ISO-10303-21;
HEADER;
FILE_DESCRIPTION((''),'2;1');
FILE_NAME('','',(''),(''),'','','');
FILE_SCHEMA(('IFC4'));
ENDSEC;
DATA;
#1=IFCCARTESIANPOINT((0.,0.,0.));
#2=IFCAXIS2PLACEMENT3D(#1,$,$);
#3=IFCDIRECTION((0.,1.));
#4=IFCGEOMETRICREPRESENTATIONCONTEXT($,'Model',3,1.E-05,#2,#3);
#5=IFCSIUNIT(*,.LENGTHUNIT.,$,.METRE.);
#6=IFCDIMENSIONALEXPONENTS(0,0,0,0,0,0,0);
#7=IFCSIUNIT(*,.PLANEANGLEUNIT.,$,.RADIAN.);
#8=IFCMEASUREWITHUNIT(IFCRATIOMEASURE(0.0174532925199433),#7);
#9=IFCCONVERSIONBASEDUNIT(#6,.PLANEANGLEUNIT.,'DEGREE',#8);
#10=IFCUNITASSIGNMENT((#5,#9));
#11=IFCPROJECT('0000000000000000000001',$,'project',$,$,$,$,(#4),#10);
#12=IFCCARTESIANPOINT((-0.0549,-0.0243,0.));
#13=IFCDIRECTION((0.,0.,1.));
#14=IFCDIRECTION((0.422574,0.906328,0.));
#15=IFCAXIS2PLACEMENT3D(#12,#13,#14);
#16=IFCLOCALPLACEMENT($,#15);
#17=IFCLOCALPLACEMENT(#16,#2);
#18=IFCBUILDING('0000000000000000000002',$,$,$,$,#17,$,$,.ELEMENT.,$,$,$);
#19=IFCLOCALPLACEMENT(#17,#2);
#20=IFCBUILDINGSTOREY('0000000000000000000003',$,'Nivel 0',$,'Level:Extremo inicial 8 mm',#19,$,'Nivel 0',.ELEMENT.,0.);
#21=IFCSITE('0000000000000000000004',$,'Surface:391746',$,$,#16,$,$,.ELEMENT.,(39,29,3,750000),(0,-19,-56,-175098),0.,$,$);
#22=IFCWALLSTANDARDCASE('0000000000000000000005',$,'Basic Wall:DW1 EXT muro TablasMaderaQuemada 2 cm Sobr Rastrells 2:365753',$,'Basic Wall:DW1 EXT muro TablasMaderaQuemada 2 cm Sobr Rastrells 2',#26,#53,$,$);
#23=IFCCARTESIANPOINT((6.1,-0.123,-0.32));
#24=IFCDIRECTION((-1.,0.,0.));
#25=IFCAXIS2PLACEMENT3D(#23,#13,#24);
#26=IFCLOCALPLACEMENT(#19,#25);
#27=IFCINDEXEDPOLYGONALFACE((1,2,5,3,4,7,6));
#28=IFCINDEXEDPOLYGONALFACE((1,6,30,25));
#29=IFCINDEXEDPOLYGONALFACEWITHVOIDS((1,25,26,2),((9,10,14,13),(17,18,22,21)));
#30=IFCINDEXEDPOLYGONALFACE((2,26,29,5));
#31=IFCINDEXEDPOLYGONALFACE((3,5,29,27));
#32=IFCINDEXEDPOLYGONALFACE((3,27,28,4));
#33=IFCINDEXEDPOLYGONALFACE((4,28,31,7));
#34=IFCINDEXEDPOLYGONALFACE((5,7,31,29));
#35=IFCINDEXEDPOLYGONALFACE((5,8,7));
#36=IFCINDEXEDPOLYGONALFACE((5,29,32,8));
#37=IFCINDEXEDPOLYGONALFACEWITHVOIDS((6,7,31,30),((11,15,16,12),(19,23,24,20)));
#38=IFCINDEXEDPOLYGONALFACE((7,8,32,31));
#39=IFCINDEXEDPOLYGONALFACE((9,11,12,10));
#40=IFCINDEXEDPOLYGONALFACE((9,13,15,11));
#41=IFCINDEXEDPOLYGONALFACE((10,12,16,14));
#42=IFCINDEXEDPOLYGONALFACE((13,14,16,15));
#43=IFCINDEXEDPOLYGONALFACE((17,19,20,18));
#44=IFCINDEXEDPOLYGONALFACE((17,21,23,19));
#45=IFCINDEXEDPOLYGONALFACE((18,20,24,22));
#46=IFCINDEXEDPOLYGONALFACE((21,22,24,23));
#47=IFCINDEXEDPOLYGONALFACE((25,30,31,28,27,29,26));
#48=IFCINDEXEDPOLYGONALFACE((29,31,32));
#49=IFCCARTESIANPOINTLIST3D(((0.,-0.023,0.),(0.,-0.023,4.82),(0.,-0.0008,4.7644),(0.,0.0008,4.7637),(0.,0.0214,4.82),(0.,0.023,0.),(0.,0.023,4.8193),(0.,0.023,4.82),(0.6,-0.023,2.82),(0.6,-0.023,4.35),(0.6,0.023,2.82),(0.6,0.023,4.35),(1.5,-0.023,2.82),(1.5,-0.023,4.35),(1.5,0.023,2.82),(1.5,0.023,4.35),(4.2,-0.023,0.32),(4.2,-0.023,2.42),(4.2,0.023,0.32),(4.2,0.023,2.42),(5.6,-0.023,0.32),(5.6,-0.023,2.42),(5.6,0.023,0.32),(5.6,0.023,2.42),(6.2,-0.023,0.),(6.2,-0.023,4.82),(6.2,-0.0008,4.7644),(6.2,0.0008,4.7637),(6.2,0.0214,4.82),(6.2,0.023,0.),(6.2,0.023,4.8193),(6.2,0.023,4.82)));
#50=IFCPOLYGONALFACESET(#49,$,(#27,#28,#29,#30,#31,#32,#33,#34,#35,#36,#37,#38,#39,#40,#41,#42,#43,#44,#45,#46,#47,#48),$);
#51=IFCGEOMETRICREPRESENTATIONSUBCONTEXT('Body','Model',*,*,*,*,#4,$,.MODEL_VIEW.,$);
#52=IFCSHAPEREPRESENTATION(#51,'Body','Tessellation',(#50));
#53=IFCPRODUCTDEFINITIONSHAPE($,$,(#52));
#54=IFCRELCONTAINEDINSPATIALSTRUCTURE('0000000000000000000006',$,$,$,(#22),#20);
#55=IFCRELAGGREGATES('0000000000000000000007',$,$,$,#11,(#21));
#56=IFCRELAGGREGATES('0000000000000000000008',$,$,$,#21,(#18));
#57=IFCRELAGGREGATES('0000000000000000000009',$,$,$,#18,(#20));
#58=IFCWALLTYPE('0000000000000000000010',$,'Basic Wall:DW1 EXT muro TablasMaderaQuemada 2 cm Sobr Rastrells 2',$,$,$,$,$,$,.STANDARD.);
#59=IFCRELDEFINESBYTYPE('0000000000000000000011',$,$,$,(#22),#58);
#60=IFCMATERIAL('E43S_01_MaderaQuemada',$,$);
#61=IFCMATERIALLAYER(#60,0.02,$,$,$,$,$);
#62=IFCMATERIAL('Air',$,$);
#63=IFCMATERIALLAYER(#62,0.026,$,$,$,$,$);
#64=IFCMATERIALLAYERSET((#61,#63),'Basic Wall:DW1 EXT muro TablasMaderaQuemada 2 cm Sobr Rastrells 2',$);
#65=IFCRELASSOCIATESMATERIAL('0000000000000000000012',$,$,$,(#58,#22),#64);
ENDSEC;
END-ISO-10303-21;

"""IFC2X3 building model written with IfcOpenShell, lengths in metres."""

from ifc_helpers import new_model, entity, si_unit, converted_unit, direction, frame, frame_2d, origin, origin_2d_with_axis, place, context, subcontext, project, spatial, rectangle, extrude, material, layer, layer_set, layer_usage, type_object, element, save


model = new_model("IFC2X3")

# Units and contexts
model_context = context("Model", 3, precision=1e-05, world=origin(), true_north=direction((0.0, 1.0)))
body_context = subcontext(model_context, "Body", "Model", "MODEL_VIEW")
ifc_project = project(units=[si_unit("LENGTHUNIT", "METRE"), converted_unit("PLANEANGLEUNIT", "DEGREE", entity("IfcRatioMeasure", 0.0174532925199433), si_unit("PLANEANGLEUNIT", "RADIAN"), dimensions=[0, 0, 0, 0, 0, 0, 0])], contexts=[model_context])

# Site, building, storey
site_placement = place(None, frame((-0.0549, -0.0243, 0.0), z_axis=(0.0, 0.0, 1.0), x_axis=(0.422574, 0.906328, 0.0)))
site = spatial("IfcSite", under=ifc_project, at=site_placement, Name="Surface:391746", CompositionType="ELEMENT", RefLatitude=(39, 29, 3, 750000), RefLongitude=(0, -19, -56, -175098), RefElevation=0.0)
building_placement = place(site_placement, origin())
building = spatial("IfcBuilding", under=site, at=building_placement, CompositionType="ELEMENT")
storey_placement = place(building_placement, origin())
storey = spatial("IfcBuildingStorey", under=building, at=storey_placement, Name="Nivel 0", ObjectType="Level:Extremo inicial 8 mm", LongName="Nivel 0", CompositionType="ELEMENT", Elevation=0.0)

# Shared definitions
ifc_material_1 = material(Name="E43S_01_MaderaQuemada")
ifc_layer_1 = layer(ifc_material_1, 0.02)
ifc_material_2 = material(Name="Air")
ifc_layer_2 = layer(ifc_material_2, 0.026)
ifc_layer_set_1 = layer_set([ifc_layer_1, ifc_layer_2], Name="Basic Wall:DW1 EXT muro TablasMaderaQuemada 2 cm Sobr Rastrells 2")
wall_type_1 = type_object("IfcWallType", Name="Basic Wall:DW1 EXT muro TablasMaderaQuemada 2 cm Sobr Rastrells 2", PredefinedType="STANDARD", material=ifc_layer_set_1)

# Wall, openings
ifc_layer_usage_1 = layer_usage(ifc_layer_set_1, "AXIS2", "NEGATIVE", 0.023)
wall_1_placement = place(storey_placement, frame((6.1, -0.123, -0.32), z_axis=(0.0, 0.0, 1.0), x_axis=(-1.0, 0.0, 0.0)))
wall_1 = element("IfcWallStandardCase", 1, at=wall_1_placement, inside=storey, type_object=wall_type_1, material=ifc_layer_usage_1, Name="Basic Wall:DW1 EXT muro TablasMaderaQuemada 2 cm Sobr Rastrells 2:365753", ObjectType="Basic Wall:DW1 EXT muro TablasMaderaQuemada 2 cm Sobr Rastrells 2", context=body_context, shape_type="SweptSolid", body=[
    extrude(rectangle(XDim=6.2, YDim=0.046, at=frame_2d((3.1, 0.0), x_axis=(-1.0, 0.0))), origin(), (0.0, 0.0, 1.0), 4.82),
])
opening_1_placement = place(storey_placement, frame((6.1, -0.123, -0.32), z_axis=(0.0, 0.0, 1.0), x_axis=(-1.0, 0.0, 0.0)))
element("IfcOpeningElement", 2, at=opening_1_placement, cuts=wall_1, ObjectType="Opening", context=body_context, shape_type="SweptSolid", body=[
    extrude(rectangle(XDim=0.0018, YDim=6.2, at=frame_2d((0.0, 0.0), x_axis=(0.0, 1.0))), frame((3.1, 0.0222, 4.8197), z_axis=(0.0, -0.370288, -0.928917), x_axis=(1.0, 0.0, 0.0)), (0.0, 0.0, 1.0), 0.0599),
])
opening_2_placement = place(wall_1_placement, origin())
element("IfcOpeningElement", 3, at=opening_2_placement, cuts=wall_1, ObjectType="Opening", context=body_context, shape_type="SweptSolid", body=[
    extrude(rectangle(XDim=1.53, YDim=0.9, at=frame_2d((0.0, 0.0), x_axis=(1.0, 0.0))), frame((1.05, -1.547, 3.585), z_axis=(0.0, 1.0, 0.0), x_axis=(0.0, 0.0, -1.0)), (0.0, 0.0, 1.0), 3.048),
])
opening_3_placement = place(wall_1_placement, origin())
element("IfcOpeningElement", 4, at=opening_3_placement, cuts=wall_1, ObjectType="Opening", context=body_context, shape_type="SweptSolid", body=[
    extrude(rectangle(XDim=2.1, YDim=1.4, at=origin_2d_with_axis()), frame((4.9, -1.547, 1.37), z_axis=(0.0, 1.0, 0.0), x_axis=(0.0, 0.0, -1.0)), (0.0, 0.0, 1.0), 3.048),
])

save(model, "model.ifc")
